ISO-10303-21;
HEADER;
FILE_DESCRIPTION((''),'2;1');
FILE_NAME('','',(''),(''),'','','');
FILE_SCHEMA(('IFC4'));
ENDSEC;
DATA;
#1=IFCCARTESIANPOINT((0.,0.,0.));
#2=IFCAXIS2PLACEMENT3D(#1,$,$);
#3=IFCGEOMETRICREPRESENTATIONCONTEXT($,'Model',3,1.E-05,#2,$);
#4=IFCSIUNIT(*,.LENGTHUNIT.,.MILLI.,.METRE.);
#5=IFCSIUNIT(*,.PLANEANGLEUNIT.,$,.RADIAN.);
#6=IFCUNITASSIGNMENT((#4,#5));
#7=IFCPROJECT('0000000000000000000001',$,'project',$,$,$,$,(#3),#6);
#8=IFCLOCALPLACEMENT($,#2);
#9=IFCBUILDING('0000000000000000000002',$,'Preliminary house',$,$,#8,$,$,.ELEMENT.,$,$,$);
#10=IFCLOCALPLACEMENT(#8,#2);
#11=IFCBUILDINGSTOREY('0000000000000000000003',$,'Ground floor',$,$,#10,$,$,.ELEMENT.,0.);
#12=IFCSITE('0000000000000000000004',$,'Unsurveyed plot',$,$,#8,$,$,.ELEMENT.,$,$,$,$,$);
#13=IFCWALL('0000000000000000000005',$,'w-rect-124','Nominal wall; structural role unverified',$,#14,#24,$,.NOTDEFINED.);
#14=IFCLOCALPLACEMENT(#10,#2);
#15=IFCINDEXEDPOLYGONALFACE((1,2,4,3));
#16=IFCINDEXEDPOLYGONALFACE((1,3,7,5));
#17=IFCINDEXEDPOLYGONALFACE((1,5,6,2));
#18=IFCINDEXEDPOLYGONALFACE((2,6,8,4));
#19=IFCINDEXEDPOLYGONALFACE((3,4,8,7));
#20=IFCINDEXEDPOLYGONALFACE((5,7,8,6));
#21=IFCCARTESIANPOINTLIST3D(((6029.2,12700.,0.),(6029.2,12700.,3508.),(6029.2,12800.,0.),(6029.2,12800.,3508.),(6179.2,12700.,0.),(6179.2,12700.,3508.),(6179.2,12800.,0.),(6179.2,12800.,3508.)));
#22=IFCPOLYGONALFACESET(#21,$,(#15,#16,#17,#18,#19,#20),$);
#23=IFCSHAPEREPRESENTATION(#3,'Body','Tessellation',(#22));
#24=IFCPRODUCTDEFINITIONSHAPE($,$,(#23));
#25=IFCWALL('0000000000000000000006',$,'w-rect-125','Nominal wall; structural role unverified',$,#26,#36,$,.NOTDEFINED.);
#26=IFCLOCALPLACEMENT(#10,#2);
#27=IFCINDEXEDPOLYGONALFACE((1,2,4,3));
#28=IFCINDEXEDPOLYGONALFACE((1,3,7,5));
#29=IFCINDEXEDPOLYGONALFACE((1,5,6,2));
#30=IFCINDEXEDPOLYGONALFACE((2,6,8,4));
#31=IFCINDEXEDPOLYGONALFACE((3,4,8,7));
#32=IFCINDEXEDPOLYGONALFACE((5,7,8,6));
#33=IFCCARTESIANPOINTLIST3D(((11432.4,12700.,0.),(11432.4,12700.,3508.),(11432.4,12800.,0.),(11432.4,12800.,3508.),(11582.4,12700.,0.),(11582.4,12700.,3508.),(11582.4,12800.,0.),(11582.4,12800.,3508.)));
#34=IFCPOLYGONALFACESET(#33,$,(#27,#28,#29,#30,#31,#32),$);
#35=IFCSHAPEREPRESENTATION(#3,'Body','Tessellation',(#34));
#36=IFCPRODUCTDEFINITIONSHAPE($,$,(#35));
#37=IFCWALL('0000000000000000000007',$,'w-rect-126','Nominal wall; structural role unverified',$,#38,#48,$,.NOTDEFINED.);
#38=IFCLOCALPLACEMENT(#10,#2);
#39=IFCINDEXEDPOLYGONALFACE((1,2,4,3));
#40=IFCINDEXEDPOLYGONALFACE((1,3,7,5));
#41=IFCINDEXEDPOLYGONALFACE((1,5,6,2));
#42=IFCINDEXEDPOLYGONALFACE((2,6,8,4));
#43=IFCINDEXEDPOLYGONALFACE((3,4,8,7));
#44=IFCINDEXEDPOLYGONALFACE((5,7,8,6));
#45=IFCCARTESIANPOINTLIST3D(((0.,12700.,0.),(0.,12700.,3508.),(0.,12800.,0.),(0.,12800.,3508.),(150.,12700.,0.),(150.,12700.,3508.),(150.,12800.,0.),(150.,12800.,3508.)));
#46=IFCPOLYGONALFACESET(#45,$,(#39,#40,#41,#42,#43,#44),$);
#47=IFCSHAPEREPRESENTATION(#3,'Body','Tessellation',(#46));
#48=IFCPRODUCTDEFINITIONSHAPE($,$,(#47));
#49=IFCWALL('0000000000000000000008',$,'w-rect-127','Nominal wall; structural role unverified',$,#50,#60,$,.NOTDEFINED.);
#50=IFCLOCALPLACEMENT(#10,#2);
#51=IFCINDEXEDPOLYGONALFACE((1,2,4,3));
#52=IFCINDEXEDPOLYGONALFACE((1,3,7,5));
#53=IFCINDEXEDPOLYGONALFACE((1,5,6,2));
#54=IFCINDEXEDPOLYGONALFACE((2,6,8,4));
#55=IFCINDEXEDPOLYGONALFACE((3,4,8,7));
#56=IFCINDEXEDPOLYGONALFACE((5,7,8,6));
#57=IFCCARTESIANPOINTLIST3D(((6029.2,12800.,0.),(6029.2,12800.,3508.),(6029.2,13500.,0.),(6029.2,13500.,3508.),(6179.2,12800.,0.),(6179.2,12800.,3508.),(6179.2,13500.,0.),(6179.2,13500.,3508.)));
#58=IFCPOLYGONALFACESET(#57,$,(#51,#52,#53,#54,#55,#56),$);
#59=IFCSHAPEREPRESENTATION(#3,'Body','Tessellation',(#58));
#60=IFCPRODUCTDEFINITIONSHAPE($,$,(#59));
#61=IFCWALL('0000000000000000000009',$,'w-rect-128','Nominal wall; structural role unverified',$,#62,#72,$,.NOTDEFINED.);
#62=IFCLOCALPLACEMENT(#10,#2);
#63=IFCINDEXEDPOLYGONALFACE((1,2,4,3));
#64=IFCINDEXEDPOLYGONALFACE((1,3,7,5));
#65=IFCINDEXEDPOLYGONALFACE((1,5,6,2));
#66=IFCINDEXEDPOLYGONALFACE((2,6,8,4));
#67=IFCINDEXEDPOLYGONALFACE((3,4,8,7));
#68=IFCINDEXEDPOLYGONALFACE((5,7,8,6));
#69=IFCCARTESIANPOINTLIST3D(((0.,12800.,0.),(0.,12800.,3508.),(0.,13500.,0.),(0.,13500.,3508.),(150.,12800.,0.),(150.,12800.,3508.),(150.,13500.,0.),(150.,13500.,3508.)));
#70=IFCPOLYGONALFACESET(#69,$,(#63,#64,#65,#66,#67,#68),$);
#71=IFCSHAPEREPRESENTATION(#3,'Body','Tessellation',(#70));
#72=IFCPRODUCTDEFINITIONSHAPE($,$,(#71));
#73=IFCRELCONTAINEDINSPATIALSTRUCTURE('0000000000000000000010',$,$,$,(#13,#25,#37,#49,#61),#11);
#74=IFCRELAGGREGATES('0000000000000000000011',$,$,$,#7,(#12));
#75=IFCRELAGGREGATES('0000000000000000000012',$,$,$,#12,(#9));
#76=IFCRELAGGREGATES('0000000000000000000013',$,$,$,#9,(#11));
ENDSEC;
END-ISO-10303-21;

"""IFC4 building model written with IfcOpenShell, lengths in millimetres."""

from ifc_helpers import new_model, si_unit, origin, place, context, project, spatial, polyline, outline, extrude, element, save


model = new_model("IFC4")

# Units and contexts
model_context = context("Model", 3, precision=1e-05, world=origin())
ifc_project = project(units=[si_unit("LENGTHUNIT", "METRE", prefix="MILLI"), si_unit("PLANEANGLEUNIT", "RADIAN")], contexts=[model_context])

# Site, building, storey
placement_1 = place(None, origin())
site = spatial("IfcSite", under=ifc_project, at=placement_1, Name="Unsurveyed plot", CompositionType="ELEMENT")
building = spatial("IfcBuilding", under=site, at=placement_1, Name="Preliminary house", CompositionType="ELEMENT")
placement_2 = place(placement_1, origin())
storey = spatial("IfcBuildingStorey", under=building, at=placement_2, Name="Ground floor", CompositionType="ELEMENT", Elevation=0.0)

# Walls
element("IfcWall", 1, at=placement_2, inside=storey, Name="w-rect-124", Description="Nominal wall; structural role unverified", PredefinedType="NOTDEFINED", context=model_context, shape_type="SweptSolid", body=[
    extrude(outline(polyline([(6029.2, 12700.0), (6179.2, 12700.0), (6179.2, 12800.0), (6029.2, 12800.0), (6029.2, 12700.0)])), origin(), (0.0, 0.0, 1.0), 3508.0),
])
element("IfcWall", 2, at=placement_2, inside=storey, Name="w-rect-125", Description="Nominal wall; structural role unverified", PredefinedType="NOTDEFINED", context=model_context, shape_type="SweptSolid", body=[
    extrude(outline(polyline([(11432.4, 12700.0), (11582.4, 12700.0), (11582.4, 12800.0), (11432.4, 12800.0), (11432.4, 12700.0)])), origin(), (0.0, 0.0, 1.0), 3508.0),
])
element("IfcWall", 3, at=placement_2, inside=storey, Name="w-rect-126", Description="Nominal wall; structural role unverified", PredefinedType="NOTDEFINED", context=model_context, shape_type="SweptSolid", body=[
    extrude(outline(polyline([(0.0, 12700.0), (150.0, 12700.0), (150.0, 12800.0), (0.0, 12800.0), (0.0, 12700.0)])), origin(), (0.0, 0.0, 1.0), 3508.0),
])
element("IfcWall", 4, at=placement_2, inside=storey, Name="w-rect-127", Description="Nominal wall; structural role unverified", PredefinedType="NOTDEFINED", context=model_context, shape_type="SweptSolid", body=[
    extrude(outline(polyline([(6029.2, 12800.0), (6179.2, 12800.0), (6179.2, 13500.0), (6029.2, 13500.0), (6029.2, 12800.0)])), origin(), (0.0, 0.0, 1.0), 3508.0),
])
element("IfcWall", 5, at=placement_2, inside=storey, Name="w-rect-128", Description="Nominal wall; structural role unverified", PredefinedType="NOTDEFINED", context=model_context, shape_type="SweptSolid", body=[
    extrude(outline(polyline([(0.0, 12800.0), (150.0, 12800.0), (150.0, 13500.0), (0.0, 13500.0), (0.0, 12800.0)])), origin(), (0.0, 0.0, 1.0), 3508.0),
])

save(model, "model.ifc")
